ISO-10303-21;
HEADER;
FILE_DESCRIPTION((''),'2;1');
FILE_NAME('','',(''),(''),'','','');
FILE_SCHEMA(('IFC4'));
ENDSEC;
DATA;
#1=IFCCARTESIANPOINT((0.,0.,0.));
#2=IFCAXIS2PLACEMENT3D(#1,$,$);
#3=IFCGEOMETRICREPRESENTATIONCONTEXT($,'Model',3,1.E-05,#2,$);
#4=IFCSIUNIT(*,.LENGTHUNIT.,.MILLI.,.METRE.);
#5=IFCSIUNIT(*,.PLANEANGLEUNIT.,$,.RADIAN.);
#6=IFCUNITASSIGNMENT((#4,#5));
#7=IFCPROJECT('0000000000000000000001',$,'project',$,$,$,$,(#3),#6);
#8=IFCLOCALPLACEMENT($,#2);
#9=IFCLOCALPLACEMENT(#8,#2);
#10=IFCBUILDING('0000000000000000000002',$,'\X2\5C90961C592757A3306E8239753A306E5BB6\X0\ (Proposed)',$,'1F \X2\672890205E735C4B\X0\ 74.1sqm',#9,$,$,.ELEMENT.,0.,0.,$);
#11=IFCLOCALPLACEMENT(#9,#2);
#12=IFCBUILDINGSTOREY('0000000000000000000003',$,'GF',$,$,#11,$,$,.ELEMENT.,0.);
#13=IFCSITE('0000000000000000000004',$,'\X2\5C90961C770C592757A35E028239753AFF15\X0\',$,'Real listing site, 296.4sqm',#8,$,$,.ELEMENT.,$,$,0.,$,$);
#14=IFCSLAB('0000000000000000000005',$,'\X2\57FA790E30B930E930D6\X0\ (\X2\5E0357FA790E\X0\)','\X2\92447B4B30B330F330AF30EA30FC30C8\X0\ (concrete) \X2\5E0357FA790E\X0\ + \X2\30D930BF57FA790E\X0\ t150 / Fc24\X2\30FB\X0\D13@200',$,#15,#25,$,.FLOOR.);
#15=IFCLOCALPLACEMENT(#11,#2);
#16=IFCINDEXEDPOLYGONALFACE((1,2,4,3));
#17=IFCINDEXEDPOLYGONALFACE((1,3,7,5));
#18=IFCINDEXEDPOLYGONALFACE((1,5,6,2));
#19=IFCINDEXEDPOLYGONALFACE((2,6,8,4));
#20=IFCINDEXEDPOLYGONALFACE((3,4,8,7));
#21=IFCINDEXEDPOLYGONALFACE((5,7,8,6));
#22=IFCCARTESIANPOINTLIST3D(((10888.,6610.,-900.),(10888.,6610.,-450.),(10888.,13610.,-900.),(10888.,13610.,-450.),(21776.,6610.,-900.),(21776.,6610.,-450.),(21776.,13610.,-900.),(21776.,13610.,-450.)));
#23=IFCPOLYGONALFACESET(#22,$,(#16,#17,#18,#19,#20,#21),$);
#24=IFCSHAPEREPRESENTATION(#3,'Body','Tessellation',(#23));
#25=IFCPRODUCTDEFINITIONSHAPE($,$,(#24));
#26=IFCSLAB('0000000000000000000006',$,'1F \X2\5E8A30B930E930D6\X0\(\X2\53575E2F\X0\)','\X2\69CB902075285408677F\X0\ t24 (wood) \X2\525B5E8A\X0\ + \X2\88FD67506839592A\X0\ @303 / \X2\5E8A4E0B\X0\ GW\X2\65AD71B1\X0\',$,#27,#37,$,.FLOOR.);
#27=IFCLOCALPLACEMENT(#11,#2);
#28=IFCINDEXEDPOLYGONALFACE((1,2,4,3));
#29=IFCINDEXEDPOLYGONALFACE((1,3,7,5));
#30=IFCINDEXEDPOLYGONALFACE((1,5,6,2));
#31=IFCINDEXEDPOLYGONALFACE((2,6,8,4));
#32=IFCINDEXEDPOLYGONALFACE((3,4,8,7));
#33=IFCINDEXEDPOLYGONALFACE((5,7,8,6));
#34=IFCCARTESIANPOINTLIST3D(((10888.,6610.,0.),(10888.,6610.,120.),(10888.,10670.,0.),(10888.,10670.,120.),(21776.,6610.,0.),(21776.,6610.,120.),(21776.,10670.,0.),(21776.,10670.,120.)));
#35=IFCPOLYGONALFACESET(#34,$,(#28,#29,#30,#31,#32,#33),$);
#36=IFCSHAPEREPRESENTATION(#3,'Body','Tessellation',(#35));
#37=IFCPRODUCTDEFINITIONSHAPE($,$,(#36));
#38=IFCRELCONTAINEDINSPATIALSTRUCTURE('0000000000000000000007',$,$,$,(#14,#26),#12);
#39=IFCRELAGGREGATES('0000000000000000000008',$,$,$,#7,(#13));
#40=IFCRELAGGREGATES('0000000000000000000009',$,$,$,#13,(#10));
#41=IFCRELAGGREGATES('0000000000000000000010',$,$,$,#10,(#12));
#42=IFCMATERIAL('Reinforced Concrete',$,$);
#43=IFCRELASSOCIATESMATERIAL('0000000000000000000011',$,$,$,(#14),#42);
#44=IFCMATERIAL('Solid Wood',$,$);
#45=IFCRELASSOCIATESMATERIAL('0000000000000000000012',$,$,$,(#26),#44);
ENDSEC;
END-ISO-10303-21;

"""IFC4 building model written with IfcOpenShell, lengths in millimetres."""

from ifc_helpers import new_model, si_unit, frame, frame_2d, origin, place, context, project, spatial, rectangle, extrude, material, element, save


model = new_model("IFC4")

# Units and contexts
model_context = context("Model", 3, precision=1e-05, world=origin())
ifc_project = project(units=[si_unit("LENGTHUNIT", "METRE", prefix="MILLI"), si_unit("PLANEANGLEUNIT", "RADIAN")], contexts=[model_context])

# Site, building, storey
site_placement = place(None, origin())
site = spatial("IfcSite", under=ifc_project, at=site_placement, Name="岐阜県大垣市船町５", ObjectType="Real listing site, 296.4sqm", CompositionType="ELEMENT", RefElevation=0.0)
building_placement = place(site_placement, origin())
building = spatial("IfcBuilding", under=site, at=building_placement, Name="岐阜大垣の船町の家 (Proposed)", ObjectType="1F 木造平屋 74.1sqm", CompositionType="ELEMENT", ElevationOfRefHeight=0.0, ElevationOfTerrain=0.0)
storey_placement = place(building_placement, origin())
storey = spatial("IfcBuildingStorey", under=building, at=storey_placement, Name="GF", CompositionType="ELEMENT", Elevation=0.0)

# Slabs
ifc_material_1 = material(Name="Reinforced Concrete")
slab_1_placement = place(storey_placement, frame((5444.0, 3305.0, -450.0)))
element("IfcSlab", 1, at=slab_1_placement, inside=storey, material=ifc_material_1, Name="基礎スラブ (布基礎)", Description="鉄筋コンクリート (concrete) 布基礎 + ベタ基礎 t150 / Fc24・D13@200", PredefinedType="FLOOR", context=model_context, shape_type="SweptSolid", body=[
    extrude(rectangle(XDim=10888.0, YDim=7000.0, at=frame_2d((5444.0, 3500.0))), frame((5444.0, 3305.0, -450.0)), (0.0, 0.0, 1.0), 450.0),
])
ifc_material_2 = material(Name="Solid Wood")
slab_2_placement = place(storey_placement, frame((5444.0, 3305.0, 0.0)))
element("IfcSlab", 2, at=slab_2_placement, inside=storey, material=ifc_material_2, Name="1F 床スラブ(南帯)", Description="構造用合板 t24 (wood) 剛床 + 製材根太 @303 / 床下 GW断熱", PredefinedType="FLOOR", context=model_context, shape_type="SweptSolid", body=[
    extrude(rectangle(XDim=10888.0, YDim=4060.0, at=frame_2d((5444.0, 2030.0))), frame((5444.0, 3305.0, 0.0)), (0.0, 0.0, 1.0), 120.0),
])

save(model, "model.ifc")
